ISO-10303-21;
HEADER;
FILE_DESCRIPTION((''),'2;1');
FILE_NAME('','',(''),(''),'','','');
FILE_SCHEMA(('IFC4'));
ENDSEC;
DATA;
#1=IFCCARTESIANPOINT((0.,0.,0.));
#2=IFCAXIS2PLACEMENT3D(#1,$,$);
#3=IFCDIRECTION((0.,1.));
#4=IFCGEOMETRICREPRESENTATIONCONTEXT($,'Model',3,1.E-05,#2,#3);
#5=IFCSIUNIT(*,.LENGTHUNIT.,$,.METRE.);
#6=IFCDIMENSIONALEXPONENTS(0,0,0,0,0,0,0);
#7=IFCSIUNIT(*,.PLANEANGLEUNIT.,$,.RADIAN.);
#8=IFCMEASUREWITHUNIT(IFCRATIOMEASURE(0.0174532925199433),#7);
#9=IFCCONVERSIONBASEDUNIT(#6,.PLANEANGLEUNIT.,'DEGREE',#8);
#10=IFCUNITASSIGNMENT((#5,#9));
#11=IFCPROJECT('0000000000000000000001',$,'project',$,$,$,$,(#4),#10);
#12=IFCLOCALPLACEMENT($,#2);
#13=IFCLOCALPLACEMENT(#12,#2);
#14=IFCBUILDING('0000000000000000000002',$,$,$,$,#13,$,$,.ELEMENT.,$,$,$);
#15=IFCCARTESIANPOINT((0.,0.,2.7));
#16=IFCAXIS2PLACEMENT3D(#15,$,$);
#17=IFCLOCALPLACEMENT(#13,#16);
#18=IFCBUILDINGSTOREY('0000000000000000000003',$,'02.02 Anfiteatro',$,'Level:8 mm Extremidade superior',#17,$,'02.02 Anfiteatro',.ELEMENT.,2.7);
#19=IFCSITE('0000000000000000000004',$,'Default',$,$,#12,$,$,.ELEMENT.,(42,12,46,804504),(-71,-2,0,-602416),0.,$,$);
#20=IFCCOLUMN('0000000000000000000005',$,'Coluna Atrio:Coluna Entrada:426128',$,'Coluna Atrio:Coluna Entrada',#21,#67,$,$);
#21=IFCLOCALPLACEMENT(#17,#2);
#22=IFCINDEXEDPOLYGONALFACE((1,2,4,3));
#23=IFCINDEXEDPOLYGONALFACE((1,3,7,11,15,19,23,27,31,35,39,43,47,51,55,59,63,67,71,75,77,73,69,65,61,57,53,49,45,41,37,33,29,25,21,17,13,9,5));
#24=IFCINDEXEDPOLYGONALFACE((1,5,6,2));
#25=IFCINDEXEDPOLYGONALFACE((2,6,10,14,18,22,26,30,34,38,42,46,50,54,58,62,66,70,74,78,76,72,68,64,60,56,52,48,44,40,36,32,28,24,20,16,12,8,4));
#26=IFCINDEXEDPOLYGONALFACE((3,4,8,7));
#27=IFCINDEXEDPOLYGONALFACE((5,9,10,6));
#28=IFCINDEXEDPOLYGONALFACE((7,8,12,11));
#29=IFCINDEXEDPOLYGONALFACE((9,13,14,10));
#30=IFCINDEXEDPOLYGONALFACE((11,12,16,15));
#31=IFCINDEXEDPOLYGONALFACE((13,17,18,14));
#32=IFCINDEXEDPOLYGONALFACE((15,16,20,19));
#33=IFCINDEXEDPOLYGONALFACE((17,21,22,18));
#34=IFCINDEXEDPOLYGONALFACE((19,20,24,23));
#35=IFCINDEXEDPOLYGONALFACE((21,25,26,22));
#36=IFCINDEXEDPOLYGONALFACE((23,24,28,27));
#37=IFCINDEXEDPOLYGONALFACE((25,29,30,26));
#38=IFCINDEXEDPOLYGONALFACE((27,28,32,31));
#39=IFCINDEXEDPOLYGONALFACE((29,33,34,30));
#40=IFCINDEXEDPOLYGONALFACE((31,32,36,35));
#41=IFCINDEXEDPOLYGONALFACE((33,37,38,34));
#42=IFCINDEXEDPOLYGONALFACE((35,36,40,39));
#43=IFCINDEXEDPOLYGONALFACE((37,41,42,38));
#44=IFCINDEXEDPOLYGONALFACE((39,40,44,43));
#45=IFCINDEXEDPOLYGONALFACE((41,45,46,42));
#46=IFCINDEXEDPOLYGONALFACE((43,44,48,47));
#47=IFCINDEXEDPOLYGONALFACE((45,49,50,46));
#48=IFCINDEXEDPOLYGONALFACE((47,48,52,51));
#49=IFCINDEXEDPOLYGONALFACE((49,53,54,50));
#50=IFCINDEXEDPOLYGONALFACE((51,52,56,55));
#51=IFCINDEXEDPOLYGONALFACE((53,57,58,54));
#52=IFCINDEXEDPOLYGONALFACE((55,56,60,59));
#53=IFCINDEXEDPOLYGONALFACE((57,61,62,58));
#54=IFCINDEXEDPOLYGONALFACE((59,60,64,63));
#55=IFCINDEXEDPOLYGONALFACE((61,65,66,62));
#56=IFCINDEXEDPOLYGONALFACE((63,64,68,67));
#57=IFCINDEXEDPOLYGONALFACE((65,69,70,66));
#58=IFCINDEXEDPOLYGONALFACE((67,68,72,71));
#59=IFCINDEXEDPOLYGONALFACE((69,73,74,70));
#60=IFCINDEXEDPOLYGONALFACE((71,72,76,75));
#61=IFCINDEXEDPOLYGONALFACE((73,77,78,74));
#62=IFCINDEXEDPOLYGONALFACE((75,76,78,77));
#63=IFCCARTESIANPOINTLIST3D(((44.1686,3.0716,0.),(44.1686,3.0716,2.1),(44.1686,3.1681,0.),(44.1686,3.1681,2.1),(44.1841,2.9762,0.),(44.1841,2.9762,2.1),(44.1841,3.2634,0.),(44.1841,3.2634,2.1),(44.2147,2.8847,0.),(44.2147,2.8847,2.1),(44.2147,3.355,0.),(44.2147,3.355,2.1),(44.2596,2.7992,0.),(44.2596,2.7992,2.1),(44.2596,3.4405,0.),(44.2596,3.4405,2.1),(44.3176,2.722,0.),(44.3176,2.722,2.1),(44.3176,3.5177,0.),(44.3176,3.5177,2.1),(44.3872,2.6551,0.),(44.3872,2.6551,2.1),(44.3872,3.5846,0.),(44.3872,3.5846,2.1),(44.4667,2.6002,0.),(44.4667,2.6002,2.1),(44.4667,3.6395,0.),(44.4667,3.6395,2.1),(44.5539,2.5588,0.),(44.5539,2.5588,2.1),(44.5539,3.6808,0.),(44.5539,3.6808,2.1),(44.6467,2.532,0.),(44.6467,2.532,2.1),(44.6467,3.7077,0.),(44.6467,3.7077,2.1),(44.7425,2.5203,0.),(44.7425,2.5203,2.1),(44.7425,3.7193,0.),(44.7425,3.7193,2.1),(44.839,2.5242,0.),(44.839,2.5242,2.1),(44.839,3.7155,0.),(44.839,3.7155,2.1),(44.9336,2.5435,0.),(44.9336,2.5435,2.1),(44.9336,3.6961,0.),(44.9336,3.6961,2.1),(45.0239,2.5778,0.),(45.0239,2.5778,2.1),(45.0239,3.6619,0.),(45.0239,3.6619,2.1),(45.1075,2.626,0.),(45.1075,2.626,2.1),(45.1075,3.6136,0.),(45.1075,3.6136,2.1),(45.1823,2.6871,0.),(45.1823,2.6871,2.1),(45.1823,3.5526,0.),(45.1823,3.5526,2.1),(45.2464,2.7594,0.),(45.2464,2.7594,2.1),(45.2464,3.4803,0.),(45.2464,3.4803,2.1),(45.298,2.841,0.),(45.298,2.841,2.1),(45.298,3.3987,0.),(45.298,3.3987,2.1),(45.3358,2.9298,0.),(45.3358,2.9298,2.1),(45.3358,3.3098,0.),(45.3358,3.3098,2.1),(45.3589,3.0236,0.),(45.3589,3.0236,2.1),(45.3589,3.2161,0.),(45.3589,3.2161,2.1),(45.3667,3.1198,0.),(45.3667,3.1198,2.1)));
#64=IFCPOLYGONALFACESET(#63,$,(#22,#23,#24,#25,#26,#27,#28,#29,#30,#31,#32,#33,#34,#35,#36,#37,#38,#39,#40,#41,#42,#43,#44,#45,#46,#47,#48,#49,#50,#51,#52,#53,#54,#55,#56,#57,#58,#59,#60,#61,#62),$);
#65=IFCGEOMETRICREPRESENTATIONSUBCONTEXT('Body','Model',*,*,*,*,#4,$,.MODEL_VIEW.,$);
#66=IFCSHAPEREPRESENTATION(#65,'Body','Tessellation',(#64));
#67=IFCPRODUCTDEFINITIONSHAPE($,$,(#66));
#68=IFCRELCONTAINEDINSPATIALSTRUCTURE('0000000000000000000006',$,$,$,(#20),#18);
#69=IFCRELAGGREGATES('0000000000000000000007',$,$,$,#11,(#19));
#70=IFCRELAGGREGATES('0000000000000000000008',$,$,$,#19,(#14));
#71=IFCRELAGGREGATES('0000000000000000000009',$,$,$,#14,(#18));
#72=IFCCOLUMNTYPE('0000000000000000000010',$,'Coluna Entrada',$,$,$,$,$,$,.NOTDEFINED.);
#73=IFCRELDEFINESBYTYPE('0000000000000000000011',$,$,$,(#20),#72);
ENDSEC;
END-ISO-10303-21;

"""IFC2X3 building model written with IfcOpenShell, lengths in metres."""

from ifc_helpers import new_model, entity, si_unit, converted_unit, direction, frame, frame_2d, origin, place, context, subcontext, project, spatial, circle, extrude, source, transform, mapped, type_object, type_shapes, element, save


model = new_model("IFC2X3")

# Units and contexts
model_context = context("Model", 3, precision=1e-05, world=origin(), true_north=direction((0.0, 1.0)))
body_context = subcontext(model_context, "Body", "Model", "MODEL_VIEW")
ifc_project = project(units=[si_unit("LENGTHUNIT", "METRE"), converted_unit("PLANEANGLEUNIT", "DEGREE", entity("IfcRatioMeasure", 0.0174532925199433), si_unit("PLANEANGLEUNIT", "RADIAN"), dimensions=[0, 0, 0, 0, 0, 0, 0])], contexts=[model_context])

# Site, building, storey
site_placement = place(None, origin())
site = spatial("IfcSite", under=ifc_project, at=site_placement, Name="Default", CompositionType="ELEMENT", RefLatitude=(42, 12, 46, 804504), RefLongitude=(-71, -2, 0, -602416), RefElevation=0.0)
building_placement = place(site_placement, origin())
building = spatial("IfcBuilding", under=site, at=building_placement, CompositionType="ELEMENT")
storey_placement = place(building_placement, frame((0.0, 0.0, 2.7)))
storey = spatial("IfcBuildingStorey", under=building, at=storey_placement, Name="02.02 Anfiteatro", ObjectType="Level:8 mm Extremidade superior", LongName="02.02 Anfiteatro", CompositionType="ELEMENT", Elevation=2.7)

# Column
column_type_1 = type_object("IfcColumnType", Name="Coluna Entrada", PredefinedType="NOTDEFINED")
shared_shape_1 = source(origin(), body_context, "Body", "SweptSolid", [
    extrude(circle(Radius=0.6, at=frame_2d((0.0, 0.0), x_axis=(1.0, 0.0))), frame((0.0, 0.0, 2.7)), (0.0, 0.0, 1.0), 2.1),
])
type_shapes(column_type_1, [shared_shape_1])
column_1_placement = place(storey_placement, frame((44.7667, 3.1198, -2.7)))
element("IfcColumn", 1, at=column_1_placement, inside=storey, type_object=column_type_1, Name="Coluna Atrio:Coluna Entrada:426128", ObjectType="Coluna Atrio:Coluna Entrada", context=body_context, shape_type="MappedRepresentation", body=[
    mapped(shared_shape_1, transform((0.0, 0.0, 0.0), scale=1.0)),
])

save(model, "model.ifc")
